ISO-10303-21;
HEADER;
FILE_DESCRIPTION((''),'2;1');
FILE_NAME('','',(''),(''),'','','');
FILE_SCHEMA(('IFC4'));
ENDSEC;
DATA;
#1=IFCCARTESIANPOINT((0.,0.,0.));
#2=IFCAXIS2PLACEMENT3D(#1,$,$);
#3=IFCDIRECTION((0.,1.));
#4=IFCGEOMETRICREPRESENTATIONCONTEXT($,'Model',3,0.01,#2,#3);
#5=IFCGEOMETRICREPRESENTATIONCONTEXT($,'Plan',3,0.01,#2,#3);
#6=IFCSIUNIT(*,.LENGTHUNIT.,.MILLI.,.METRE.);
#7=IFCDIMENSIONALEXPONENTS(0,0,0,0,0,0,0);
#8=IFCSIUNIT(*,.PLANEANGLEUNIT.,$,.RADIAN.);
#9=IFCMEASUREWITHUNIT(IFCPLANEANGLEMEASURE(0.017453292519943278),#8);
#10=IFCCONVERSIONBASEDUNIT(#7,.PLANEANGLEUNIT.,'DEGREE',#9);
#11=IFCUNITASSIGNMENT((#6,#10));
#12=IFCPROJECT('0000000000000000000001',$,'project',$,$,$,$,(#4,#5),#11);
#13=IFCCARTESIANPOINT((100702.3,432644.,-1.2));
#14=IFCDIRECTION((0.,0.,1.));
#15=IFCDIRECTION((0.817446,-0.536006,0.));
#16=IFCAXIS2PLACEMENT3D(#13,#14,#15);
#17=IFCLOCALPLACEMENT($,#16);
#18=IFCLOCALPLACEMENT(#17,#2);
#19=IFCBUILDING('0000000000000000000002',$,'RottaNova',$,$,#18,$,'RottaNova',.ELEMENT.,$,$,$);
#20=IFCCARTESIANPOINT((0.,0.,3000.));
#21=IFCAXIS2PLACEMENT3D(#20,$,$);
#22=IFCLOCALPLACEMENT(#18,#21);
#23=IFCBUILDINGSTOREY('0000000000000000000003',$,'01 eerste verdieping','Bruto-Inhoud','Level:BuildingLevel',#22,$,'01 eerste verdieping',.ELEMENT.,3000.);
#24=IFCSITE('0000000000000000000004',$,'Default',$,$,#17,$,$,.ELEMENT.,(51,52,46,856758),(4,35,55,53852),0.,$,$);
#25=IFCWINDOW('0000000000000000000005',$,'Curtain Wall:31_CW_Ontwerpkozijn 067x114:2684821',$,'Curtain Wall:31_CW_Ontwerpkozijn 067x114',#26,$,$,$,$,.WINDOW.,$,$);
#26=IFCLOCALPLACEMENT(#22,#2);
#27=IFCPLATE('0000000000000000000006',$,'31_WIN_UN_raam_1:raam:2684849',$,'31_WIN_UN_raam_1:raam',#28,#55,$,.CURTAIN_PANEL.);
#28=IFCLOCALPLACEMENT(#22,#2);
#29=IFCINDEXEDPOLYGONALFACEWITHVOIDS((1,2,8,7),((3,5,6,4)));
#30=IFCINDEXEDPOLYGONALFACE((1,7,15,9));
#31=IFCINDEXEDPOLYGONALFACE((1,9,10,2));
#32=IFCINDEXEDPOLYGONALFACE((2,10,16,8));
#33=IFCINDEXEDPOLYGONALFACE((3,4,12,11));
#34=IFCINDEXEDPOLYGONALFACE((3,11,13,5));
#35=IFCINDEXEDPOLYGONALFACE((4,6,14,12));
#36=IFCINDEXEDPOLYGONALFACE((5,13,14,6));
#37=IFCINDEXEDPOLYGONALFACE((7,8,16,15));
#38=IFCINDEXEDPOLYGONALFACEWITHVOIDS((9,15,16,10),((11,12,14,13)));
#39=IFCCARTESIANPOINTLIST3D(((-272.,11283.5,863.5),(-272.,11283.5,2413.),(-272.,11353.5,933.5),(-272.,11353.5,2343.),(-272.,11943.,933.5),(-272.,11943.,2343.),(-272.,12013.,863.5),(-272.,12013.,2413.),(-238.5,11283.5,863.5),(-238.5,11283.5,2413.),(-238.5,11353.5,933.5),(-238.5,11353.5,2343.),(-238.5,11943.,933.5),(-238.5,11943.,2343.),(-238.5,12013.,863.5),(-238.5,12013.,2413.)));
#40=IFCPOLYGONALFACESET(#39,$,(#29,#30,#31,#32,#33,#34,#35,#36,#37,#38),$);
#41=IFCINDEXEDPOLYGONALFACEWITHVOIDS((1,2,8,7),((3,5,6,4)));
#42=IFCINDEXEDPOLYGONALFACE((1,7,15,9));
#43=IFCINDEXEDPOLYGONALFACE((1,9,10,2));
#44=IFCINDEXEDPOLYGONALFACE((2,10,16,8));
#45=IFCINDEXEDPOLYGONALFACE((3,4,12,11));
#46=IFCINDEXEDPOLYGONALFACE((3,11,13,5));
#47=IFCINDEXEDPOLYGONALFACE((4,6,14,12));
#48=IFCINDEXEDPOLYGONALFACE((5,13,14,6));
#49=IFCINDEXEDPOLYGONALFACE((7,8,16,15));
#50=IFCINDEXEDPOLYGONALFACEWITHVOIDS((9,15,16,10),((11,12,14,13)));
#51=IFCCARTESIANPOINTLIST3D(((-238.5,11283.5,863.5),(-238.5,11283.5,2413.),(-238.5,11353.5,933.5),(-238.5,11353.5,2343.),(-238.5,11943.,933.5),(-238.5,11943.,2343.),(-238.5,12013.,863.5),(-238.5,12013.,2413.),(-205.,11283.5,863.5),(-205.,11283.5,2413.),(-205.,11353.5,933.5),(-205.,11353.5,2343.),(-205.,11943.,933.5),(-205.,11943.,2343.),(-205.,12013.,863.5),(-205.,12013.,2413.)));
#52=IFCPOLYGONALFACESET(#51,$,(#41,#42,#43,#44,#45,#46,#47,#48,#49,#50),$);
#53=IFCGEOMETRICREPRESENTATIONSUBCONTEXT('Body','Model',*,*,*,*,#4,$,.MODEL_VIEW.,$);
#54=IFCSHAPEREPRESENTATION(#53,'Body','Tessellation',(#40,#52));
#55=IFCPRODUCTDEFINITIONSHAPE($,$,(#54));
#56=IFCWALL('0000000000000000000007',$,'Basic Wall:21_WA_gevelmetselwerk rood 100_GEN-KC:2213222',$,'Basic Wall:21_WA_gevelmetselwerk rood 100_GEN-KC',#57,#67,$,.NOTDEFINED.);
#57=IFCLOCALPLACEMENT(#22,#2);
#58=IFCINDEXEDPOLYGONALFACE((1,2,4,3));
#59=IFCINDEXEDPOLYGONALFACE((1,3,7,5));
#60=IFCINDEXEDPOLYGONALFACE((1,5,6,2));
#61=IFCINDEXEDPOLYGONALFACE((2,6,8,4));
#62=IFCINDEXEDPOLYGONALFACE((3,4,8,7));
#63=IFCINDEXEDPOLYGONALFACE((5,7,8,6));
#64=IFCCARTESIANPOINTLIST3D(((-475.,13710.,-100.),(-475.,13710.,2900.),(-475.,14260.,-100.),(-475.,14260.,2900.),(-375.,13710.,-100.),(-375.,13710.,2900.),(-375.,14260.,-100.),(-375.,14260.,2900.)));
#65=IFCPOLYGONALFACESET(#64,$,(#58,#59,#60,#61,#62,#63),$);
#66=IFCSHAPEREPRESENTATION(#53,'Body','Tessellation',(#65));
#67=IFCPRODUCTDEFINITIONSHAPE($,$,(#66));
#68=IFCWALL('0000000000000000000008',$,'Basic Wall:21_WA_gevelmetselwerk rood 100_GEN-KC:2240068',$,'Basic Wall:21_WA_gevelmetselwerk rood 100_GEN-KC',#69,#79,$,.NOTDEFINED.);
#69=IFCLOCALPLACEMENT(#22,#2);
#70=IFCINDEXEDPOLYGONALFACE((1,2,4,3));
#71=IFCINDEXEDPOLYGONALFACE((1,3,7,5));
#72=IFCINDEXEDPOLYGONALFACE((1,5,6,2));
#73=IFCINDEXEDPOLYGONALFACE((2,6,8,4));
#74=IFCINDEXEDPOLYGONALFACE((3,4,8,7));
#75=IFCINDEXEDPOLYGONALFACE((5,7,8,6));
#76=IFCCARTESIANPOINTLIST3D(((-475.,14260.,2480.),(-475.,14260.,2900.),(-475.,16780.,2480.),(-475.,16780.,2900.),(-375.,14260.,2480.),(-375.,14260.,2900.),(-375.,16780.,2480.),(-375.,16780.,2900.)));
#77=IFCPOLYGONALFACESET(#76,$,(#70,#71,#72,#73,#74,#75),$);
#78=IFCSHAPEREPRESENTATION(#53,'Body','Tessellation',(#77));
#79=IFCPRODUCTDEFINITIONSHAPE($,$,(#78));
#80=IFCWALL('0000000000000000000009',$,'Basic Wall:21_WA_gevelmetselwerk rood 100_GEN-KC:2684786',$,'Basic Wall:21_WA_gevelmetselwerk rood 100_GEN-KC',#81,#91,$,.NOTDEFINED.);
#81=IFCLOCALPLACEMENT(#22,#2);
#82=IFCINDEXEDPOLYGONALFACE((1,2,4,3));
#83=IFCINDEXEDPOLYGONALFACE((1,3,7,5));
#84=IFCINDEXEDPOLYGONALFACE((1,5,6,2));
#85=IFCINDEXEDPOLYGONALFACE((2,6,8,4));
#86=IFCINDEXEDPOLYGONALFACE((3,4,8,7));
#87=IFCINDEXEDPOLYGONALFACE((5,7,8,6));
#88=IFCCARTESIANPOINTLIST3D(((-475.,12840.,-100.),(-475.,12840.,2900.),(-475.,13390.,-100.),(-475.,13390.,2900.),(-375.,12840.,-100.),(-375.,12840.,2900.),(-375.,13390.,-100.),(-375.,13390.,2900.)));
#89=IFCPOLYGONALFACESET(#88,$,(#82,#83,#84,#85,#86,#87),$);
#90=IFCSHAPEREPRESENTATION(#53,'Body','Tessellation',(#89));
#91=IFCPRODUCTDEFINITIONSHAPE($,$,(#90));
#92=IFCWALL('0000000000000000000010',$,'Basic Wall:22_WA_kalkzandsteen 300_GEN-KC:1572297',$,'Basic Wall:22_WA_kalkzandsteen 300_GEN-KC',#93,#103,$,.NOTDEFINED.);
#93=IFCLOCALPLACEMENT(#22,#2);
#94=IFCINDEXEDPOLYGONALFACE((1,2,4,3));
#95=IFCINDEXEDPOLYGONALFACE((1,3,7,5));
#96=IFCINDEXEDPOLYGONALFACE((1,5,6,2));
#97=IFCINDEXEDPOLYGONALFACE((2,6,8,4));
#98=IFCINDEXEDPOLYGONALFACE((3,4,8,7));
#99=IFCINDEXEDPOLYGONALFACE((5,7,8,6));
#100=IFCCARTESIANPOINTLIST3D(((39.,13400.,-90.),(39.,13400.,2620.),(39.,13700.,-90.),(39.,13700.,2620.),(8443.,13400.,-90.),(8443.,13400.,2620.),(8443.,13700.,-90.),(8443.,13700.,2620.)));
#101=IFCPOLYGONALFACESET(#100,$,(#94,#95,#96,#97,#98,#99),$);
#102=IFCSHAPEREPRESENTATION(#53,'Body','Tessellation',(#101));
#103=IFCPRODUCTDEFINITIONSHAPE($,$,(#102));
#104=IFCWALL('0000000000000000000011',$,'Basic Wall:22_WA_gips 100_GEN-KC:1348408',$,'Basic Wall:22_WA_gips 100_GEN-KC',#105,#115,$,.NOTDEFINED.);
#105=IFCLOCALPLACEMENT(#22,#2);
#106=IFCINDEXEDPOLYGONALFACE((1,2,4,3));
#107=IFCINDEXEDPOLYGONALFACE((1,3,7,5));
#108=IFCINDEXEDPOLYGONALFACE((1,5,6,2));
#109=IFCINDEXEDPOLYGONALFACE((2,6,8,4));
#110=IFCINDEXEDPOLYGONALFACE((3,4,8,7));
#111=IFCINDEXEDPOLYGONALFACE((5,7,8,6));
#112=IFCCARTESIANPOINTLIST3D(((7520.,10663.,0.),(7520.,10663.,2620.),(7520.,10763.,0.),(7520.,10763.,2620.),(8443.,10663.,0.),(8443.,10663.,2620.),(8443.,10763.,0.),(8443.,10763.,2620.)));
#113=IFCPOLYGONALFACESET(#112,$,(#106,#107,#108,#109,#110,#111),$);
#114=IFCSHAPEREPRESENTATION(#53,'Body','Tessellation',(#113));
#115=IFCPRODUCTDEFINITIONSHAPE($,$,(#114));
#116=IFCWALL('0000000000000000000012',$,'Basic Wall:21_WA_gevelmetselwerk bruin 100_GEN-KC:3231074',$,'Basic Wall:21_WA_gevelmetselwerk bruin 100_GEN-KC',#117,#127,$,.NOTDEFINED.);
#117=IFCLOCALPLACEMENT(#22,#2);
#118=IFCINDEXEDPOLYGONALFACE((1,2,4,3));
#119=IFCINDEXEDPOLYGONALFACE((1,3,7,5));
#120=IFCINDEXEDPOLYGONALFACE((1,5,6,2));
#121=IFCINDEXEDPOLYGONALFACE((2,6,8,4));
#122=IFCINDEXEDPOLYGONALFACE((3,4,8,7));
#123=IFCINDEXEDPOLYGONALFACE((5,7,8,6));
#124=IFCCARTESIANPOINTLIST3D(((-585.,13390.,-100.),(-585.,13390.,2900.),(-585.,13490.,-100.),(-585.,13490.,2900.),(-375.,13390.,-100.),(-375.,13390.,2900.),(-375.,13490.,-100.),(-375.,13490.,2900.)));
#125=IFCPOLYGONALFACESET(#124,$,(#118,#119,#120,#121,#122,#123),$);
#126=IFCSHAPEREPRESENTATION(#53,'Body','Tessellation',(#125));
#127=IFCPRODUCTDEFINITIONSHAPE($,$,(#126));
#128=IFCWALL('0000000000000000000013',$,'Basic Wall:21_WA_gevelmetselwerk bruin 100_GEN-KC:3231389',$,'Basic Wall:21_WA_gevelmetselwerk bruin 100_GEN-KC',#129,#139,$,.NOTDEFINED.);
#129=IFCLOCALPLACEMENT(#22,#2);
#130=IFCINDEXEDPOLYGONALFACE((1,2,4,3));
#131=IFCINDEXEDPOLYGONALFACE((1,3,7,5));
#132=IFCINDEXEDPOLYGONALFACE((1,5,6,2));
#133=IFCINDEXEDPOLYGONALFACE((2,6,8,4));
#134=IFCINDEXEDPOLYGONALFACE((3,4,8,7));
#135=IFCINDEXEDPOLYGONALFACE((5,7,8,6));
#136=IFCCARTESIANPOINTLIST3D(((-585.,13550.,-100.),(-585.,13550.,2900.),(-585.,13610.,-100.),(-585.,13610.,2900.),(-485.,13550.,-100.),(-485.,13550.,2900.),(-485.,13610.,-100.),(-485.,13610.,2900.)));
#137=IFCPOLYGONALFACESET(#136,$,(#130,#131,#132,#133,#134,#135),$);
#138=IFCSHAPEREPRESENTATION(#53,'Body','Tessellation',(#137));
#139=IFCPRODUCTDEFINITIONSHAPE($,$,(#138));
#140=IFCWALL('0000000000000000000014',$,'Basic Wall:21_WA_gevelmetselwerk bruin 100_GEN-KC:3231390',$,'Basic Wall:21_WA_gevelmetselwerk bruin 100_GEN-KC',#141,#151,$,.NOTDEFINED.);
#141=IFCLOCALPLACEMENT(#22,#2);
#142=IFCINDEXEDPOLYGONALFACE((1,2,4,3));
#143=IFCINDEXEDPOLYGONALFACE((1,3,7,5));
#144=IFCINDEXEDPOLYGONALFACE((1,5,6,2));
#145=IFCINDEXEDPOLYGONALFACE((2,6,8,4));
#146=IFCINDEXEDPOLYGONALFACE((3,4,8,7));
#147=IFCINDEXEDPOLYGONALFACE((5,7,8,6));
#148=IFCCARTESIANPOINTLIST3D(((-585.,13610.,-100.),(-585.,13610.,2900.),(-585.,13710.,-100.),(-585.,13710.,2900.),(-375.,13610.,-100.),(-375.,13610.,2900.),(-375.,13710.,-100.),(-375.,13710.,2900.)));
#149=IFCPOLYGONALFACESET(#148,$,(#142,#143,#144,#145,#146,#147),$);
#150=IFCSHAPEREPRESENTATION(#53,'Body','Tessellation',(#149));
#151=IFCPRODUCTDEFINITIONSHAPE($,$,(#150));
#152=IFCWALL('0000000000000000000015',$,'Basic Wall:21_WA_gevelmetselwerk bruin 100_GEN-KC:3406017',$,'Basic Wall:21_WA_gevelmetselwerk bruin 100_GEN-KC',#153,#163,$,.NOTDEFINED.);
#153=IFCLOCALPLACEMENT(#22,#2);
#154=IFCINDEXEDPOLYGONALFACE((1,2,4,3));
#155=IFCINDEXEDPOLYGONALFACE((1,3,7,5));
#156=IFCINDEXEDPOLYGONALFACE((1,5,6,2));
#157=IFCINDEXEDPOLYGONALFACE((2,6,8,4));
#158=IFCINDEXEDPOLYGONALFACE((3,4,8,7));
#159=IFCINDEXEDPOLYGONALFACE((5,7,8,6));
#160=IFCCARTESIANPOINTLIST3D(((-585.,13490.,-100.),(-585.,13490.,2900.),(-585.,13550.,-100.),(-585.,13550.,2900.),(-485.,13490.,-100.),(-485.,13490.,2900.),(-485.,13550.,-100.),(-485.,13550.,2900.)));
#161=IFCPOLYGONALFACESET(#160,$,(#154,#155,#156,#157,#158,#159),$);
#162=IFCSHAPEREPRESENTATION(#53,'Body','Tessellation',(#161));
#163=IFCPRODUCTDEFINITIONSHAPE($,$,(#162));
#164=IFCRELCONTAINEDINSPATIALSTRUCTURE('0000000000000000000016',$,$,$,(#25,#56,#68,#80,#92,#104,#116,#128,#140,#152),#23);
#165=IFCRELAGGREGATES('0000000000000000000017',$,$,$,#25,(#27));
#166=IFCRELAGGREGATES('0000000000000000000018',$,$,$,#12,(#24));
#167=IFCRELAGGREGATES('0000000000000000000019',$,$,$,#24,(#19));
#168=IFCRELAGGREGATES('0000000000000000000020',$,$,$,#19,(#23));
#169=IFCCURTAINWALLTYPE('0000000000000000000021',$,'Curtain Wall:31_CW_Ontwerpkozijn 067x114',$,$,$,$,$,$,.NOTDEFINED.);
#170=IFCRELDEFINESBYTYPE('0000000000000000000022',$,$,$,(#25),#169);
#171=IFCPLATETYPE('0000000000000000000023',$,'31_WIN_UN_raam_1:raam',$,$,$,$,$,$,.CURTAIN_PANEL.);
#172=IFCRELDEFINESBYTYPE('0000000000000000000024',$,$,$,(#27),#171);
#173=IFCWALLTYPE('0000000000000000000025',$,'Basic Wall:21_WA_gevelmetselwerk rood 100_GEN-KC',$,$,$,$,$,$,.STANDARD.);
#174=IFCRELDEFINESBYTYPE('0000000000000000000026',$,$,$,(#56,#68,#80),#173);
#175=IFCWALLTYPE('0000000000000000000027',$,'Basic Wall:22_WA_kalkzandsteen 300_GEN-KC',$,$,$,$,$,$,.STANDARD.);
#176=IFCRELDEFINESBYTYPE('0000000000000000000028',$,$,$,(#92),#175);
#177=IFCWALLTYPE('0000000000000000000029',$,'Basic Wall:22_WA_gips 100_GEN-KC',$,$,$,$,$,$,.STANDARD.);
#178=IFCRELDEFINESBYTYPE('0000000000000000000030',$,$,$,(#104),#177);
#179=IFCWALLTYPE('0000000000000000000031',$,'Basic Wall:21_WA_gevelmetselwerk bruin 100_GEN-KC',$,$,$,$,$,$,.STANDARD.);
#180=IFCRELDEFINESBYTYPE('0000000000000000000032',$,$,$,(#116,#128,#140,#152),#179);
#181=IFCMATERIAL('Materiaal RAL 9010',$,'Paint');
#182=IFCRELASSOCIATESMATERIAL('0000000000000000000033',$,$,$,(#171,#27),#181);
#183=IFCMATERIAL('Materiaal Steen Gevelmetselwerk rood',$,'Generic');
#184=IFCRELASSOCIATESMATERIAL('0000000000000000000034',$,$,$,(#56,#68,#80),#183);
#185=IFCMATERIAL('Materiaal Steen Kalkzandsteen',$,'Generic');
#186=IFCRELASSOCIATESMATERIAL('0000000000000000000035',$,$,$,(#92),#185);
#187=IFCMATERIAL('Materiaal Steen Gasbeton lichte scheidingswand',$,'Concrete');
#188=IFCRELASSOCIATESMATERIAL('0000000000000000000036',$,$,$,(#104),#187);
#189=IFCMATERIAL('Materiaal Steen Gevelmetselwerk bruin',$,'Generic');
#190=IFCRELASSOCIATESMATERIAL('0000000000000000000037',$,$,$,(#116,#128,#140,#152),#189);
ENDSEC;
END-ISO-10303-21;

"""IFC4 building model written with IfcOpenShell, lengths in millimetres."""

from ifc_helpers import new_model, entity, si_unit, converted_unit, direction, frame, origin, place, context, subcontext, project, spatial, indexed_curve, outline, extrude, source, transform, mapped, material, type_object, type_shapes, element, aggregate, save


model = new_model("IFC4")

# Units and contexts
model_context = context("Model", 3, precision=0.01, world=origin(), true_north=direction((0.0, 1.0)))
plan_context = context("Plan", 3, precision=0.01, world=origin(), true_north=direction((0.0, 1.0)))
body_context = subcontext(model_context, "Body", "Model", "MODEL_VIEW")
ifc_project = project(units=[si_unit("LENGTHUNIT", "METRE", prefix="MILLI"), converted_unit("PLANEANGLEUNIT", "DEGREE", entity("IfcPlaneAngleMeasure", 0.017453292519943278), si_unit("PLANEANGLEUNIT", "RADIAN"), dimensions=[0, 0, 0, 0, 0, 0, 0])], contexts=[model_context, plan_context])

# Site, building, storey
site_placement = place(None, frame((100702.3, 432644.0, -1.2), z_axis=(0.0, 0.0, 1.0), x_axis=(0.817446, -0.536006, 0.0)))
site = spatial("IfcSite", under=ifc_project, at=site_placement, Name="Default", CompositionType="ELEMENT", RefLatitude=(51, 52, 46, 856758), RefLongitude=(4, 35, 55, 53852), RefElevation=0.0)
building_placement = place(site_placement, origin())
building = spatial("IfcBuilding", under=site, at=building_placement, Name="RottaNova", LongName="RottaNova", CompositionType="ELEMENT")
storey_placement = place(building_placement, frame((0.0, 0.0, 3000.0)))
storey = spatial("IfcBuildingStorey", under=building, at=storey_placement, Name="01 eerste verdieping", Description="Bruto-Inhoud", ObjectType="Level:BuildingLevel", LongName="01 eerste verdieping", CompositionType="ELEMENT", Elevation=3000.0)

# Window
curtain_wall_type = type_object("IfcCurtainWallType", Name="Curtain Wall:31_CW_Ontwerpkozijn 067x114", PredefinedType="NOTDEFINED")
window_1_placement = place(storey_placement, frame((0.0, 0.0, -3000.0)))
window_1 = element("IfcWindow", 1, at=window_1_placement, inside=storey, type_object=curtain_wall_type, Name="Curtain Wall:31_CW_Ontwerpkozijn 067x114:2684821", ObjectType="Curtain Wall:31_CW_Ontwerpkozijn 067x114", PredefinedType="WINDOW")

# Plate
ifc_material_1 = material(Name="Materiaal RAL 9010", Category="Paint")
plate_type_1 = type_object("IfcPlateType", Name="31_WIN_UN_raam_1:raam", PredefinedType="CURTAIN_PANEL", material=ifc_material_1)
shared_shape_1 = source(origin(), body_context, "Body", "SweptSolid", [
    extrude(outline(indexed_curve([(-364.7, -774.7), (364.7, -774.7), (364.7, 774.7), (-364.7, 774.7), (-364.7, -774.7)], self_intersect=False), holes=[indexed_curve([(-294.7, 704.7), (294.7, 704.7), (294.7, -704.8), (-294.7, -704.8), (-294.7, 704.7)], self_intersect=False)]), frame((0.0, 58.5, 774.8), z_axis=(0.0, 1.0, 0.0), x_axis=(1.0, 0.0, 0.0)), (0.0, 0.0, 1.0), 33.5),
    extrude(outline(indexed_curve([(-364.7, -774.7), (364.7, -774.7), (364.7, 774.7), (-364.7, 774.7), (-364.7, -774.7)], self_intersect=False), holes=[indexed_curve([(-294.7, 704.7), (294.7, 704.7), (294.7, -704.8), (-294.7, -704.8), (-294.7, 704.7)], self_intersect=False)]), frame((0.0, 25.0, 774.8), z_axis=(0.0, 1.0, 0.0), x_axis=(1.0, 0.0, 0.0)), (0.0, 0.0, 1.0), 33.5),
])
type_shapes(plate_type_1, [shared_shape_1])
plate_1_placement = place(window_1_placement, frame((-180.0, 11648.2, 3863.5), z_axis=(0.0, 0.0, 1.0), x_axis=(0.0, 1.0, 0.0)))
plate_1 = element("IfcPlate", 2, at=plate_1_placement, type_object=plate_type_1, material=ifc_material_1, Name="31_WIN_UN_raam_1:raam:2684849", ObjectType="31_WIN_UN_raam_1:raam", PredefinedType="CURTAIN_PANEL", context=body_context, shape_type="MappedRepresentation", body=[
    mapped(shared_shape_1, transform((0.0, 0.0, 0.0), scale=1.0)),
])
aggregate(window_1, [plate_1])

# Walls
ifc_material_2 = material(Name="Materiaal Steen Gevelmetselwerk rood", Category="Generic")
wall_type_1 = type_object("IfcWallType", Name="Basic Wall:21_WA_gevelmetselwerk rood 100_GEN-KC", PredefinedType="STANDARD")
wall_1_placement = place(storey_placement, frame((-425.0, 13710.0, -100.0), z_axis=(0.0, 0.0, 1.0), x_axis=(0.0, 1.0, 0.0)))
element("IfcWall", 3, at=wall_1_placement, inside=storey, type_object=wall_type_1, material=ifc_material_2, Name="Basic Wall:21_WA_gevelmetselwerk rood 100_GEN-KC:2213222", ObjectType="Basic Wall:21_WA_gevelmetselwerk rood 100_GEN-KC", PredefinedType="NOTDEFINED", context=body_context, shape_type="SweptSolid", body=[
    extrude(outline(indexed_curve([(550.0, 50.0), (0.0, 50.0), (0.0, -50.0), (550.0, -50.0), (550.0, 50.0)], self_intersect=False)), origin(), (0.0, 0.0, 1.0), 3000.0),
])
wall_2_placement = place(storey_placement, frame((-425.0, 14260.0, 2480.0), z_axis=(0.0, 0.0, 1.0), x_axis=(0.0, 1.0, 0.0)))
element("IfcWall", 4, at=wall_2_placement, inside=storey, type_object=wall_type_1, material=ifc_material_2, Name="Basic Wall:21_WA_gevelmetselwerk rood 100_GEN-KC:2240068", ObjectType="Basic Wall:21_WA_gevelmetselwerk rood 100_GEN-KC", PredefinedType="NOTDEFINED", context=body_context, shape_type="SweptSolid", body=[
    extrude(outline(indexed_curve([(2520.0, 50.0), (0.0, 50.0), (0.0, -50.0), (2520.0, -50.0), (2520.0, 50.0)], self_intersect=False)), origin(), (0.0, 0.0, 1.0), 420.0),
])
wall_3_placement = place(storey_placement, frame((-425.0, 12840.0, -100.0), z_axis=(0.0, 0.0, 1.0), x_axis=(0.0, 1.0, 0.0)))
element("IfcWall", 5, at=wall_3_placement, inside=storey, type_object=wall_type_1, material=ifc_material_2, Name="Basic Wall:21_WA_gevelmetselwerk rood 100_GEN-KC:2684786", ObjectType="Basic Wall:21_WA_gevelmetselwerk rood 100_GEN-KC", PredefinedType="NOTDEFINED", context=body_context, shape_type="SweptSolid", body=[
    extrude(outline(indexed_curve([(550.0, 50.0), (0.0, 50.0), (0.0, -50.0), (550.0, -50.0), (550.0, 50.0)], self_intersect=False)), origin(), (0.0, 0.0, 1.0), 3000.0),
])
ifc_material_3 = material(Name="Materiaal Steen Kalkzandsteen", Category="Generic")
wall_type_2 = type_object("IfcWallType", Name="Basic Wall:22_WA_kalkzandsteen 300_GEN-KC", PredefinedType="STANDARD")
wall_4_placement = place(storey_placement, frame((39.0, 13550.0, -90.0)))
element("IfcWall", 6, at=wall_4_placement, inside=storey, type_object=wall_type_2, material=ifc_material_3, Name="Basic Wall:22_WA_kalkzandsteen 300_GEN-KC:1572297", ObjectType="Basic Wall:22_WA_kalkzandsteen 300_GEN-KC", PredefinedType="NOTDEFINED", context=body_context, shape_type="SweptSolid", body=[
    extrude(outline(indexed_curve([(8404.0, 150.0), (0.0, 150.0), (0.0, -150.0), (8404.0, -150.0), (8404.0, 150.0)], self_intersect=False)), origin(), (0.0, 0.0, 1.0), 2710.0),
])
ifc_material_4 = material(Name="Materiaal Steen Gasbeton lichte scheidingswand", Category="Concrete")
wall_type_3 = type_object("IfcWallType", Name="Basic Wall:22_WA_gips 100_GEN-KC", PredefinedType="STANDARD")
wall_5_placement = place(storey_placement, frame((7520.0, 10713.0, 0.0)))
element("IfcWall", 7, at=wall_5_placement, inside=storey, type_object=wall_type_3, material=ifc_material_4, Name="Basic Wall:22_WA_gips 100_GEN-KC:1348408", ObjectType="Basic Wall:22_WA_gips 100_GEN-KC", PredefinedType="NOTDEFINED", context=body_context, shape_type="SweptSolid", body=[
    extrude(outline(indexed_curve([(923.0, 50.0), (0.0, 50.0), (0.0, -50.0), (923.0, -50.0), (923.0, 50.0)], self_intersect=False)), origin(), (0.0, 0.0, 1.0), 2620.0),
])
ifc_material_5 = material(Name="Materiaal Steen Gevelmetselwerk bruin", Category="Generic")
wall_type_4 = type_object("IfcWallType", Name="Basic Wall:21_WA_gevelmetselwerk bruin 100_GEN-KC", PredefinedType="STANDARD")
wall_6_placement = place(storey_placement, frame((-585.0, 13440.0, -100.0)))
element("IfcWall", 8, at=wall_6_placement, inside=storey, type_object=wall_type_4, material=ifc_material_5, Name="Basic Wall:21_WA_gevelmetselwerk bruin 100_GEN-KC:3231074", ObjectType="Basic Wall:21_WA_gevelmetselwerk bruin 100_GEN-KC", PredefinedType="NOTDEFINED", context=body_context, shape_type="SweptSolid", body=[
    extrude(outline(indexed_curve([(210.0, 50.0), (0.0, 50.0), (0.0, -50.0), (210.0, -50.0), (210.0, 50.0)], self_intersect=False)), origin(), (0.0, 0.0, 1.0), 3000.0),
])
wall_7_placement = place(storey_placement, frame((-535.0, 13550.0, -100.0), z_axis=(0.0, 0.0, 1.0), x_axis=(0.0, 1.0, 0.0)))
element("IfcWall", 9, at=wall_7_placement, inside=storey, type_object=wall_type_4, material=ifc_material_5, Name="Basic Wall:21_WA_gevelmetselwerk bruin 100_GEN-KC:3231389", ObjectType="Basic Wall:21_WA_gevelmetselwerk bruin 100_GEN-KC", PredefinedType="NOTDEFINED", context=body_context, shape_type="SweptSolid", body=[
    extrude(outline(indexed_curve([(60.0, 50.0), (0.0, 50.0), (0.0, -50.0), (60.0, -50.0), (60.0, 50.0)], self_intersect=False)), origin(), (0.0, 0.0, 1.0), 3000.0),
])
wall_8_placement = place(storey_placement, frame((-585.0, 13660.0, -100.0)))
element("IfcWall", 10, at=wall_8_placement, inside=storey, type_object=wall_type_4, material=ifc_material_5, Name="Basic Wall:21_WA_gevelmetselwerk bruin 100_GEN-KC:3231390", ObjectType="Basic Wall:21_WA_gevelmetselwerk bruin 100_GEN-KC", PredefinedType="NOTDEFINED", context=body_context, shape_type="SweptSolid", body=[
    extrude(outline(indexed_curve([(210.0, 50.0), (0.0, 50.0), (0.0, -50.0), (210.0, -50.0), (210.0, 50.0)], self_intersect=False)), origin(), (0.0, 0.0, 1.0), 3000.0),
])
wall_9_placement = place(storey_placement, frame((-535.0, 13490.0, -100.0), z_axis=(0.0, 0.0, 1.0), x_axis=(0.0, 1.0, 0.0)))
element("IfcWall", 11, at=wall_9_placement, inside=storey, type_object=wall_type_4, material=ifc_material_5, Name="Basic Wall:21_WA_gevelmetselwerk bruin 100_GEN-KC:3406017", ObjectType="Basic Wall:21_WA_gevelmetselwerk bruin 100_GEN-KC", PredefinedType="NOTDEFINED", context=body_context, shape_type="SweptSolid", body=[
    extrude(outline(indexed_curve([(60.0, 50.0), (0.0, 50.0), (0.0, -50.0), (60.0, -50.0), (60.0, 50.0)], self_intersect=False)), origin(), (0.0, 0.0, 1.0), 3000.0),
])

save(model, "model.ifc")
